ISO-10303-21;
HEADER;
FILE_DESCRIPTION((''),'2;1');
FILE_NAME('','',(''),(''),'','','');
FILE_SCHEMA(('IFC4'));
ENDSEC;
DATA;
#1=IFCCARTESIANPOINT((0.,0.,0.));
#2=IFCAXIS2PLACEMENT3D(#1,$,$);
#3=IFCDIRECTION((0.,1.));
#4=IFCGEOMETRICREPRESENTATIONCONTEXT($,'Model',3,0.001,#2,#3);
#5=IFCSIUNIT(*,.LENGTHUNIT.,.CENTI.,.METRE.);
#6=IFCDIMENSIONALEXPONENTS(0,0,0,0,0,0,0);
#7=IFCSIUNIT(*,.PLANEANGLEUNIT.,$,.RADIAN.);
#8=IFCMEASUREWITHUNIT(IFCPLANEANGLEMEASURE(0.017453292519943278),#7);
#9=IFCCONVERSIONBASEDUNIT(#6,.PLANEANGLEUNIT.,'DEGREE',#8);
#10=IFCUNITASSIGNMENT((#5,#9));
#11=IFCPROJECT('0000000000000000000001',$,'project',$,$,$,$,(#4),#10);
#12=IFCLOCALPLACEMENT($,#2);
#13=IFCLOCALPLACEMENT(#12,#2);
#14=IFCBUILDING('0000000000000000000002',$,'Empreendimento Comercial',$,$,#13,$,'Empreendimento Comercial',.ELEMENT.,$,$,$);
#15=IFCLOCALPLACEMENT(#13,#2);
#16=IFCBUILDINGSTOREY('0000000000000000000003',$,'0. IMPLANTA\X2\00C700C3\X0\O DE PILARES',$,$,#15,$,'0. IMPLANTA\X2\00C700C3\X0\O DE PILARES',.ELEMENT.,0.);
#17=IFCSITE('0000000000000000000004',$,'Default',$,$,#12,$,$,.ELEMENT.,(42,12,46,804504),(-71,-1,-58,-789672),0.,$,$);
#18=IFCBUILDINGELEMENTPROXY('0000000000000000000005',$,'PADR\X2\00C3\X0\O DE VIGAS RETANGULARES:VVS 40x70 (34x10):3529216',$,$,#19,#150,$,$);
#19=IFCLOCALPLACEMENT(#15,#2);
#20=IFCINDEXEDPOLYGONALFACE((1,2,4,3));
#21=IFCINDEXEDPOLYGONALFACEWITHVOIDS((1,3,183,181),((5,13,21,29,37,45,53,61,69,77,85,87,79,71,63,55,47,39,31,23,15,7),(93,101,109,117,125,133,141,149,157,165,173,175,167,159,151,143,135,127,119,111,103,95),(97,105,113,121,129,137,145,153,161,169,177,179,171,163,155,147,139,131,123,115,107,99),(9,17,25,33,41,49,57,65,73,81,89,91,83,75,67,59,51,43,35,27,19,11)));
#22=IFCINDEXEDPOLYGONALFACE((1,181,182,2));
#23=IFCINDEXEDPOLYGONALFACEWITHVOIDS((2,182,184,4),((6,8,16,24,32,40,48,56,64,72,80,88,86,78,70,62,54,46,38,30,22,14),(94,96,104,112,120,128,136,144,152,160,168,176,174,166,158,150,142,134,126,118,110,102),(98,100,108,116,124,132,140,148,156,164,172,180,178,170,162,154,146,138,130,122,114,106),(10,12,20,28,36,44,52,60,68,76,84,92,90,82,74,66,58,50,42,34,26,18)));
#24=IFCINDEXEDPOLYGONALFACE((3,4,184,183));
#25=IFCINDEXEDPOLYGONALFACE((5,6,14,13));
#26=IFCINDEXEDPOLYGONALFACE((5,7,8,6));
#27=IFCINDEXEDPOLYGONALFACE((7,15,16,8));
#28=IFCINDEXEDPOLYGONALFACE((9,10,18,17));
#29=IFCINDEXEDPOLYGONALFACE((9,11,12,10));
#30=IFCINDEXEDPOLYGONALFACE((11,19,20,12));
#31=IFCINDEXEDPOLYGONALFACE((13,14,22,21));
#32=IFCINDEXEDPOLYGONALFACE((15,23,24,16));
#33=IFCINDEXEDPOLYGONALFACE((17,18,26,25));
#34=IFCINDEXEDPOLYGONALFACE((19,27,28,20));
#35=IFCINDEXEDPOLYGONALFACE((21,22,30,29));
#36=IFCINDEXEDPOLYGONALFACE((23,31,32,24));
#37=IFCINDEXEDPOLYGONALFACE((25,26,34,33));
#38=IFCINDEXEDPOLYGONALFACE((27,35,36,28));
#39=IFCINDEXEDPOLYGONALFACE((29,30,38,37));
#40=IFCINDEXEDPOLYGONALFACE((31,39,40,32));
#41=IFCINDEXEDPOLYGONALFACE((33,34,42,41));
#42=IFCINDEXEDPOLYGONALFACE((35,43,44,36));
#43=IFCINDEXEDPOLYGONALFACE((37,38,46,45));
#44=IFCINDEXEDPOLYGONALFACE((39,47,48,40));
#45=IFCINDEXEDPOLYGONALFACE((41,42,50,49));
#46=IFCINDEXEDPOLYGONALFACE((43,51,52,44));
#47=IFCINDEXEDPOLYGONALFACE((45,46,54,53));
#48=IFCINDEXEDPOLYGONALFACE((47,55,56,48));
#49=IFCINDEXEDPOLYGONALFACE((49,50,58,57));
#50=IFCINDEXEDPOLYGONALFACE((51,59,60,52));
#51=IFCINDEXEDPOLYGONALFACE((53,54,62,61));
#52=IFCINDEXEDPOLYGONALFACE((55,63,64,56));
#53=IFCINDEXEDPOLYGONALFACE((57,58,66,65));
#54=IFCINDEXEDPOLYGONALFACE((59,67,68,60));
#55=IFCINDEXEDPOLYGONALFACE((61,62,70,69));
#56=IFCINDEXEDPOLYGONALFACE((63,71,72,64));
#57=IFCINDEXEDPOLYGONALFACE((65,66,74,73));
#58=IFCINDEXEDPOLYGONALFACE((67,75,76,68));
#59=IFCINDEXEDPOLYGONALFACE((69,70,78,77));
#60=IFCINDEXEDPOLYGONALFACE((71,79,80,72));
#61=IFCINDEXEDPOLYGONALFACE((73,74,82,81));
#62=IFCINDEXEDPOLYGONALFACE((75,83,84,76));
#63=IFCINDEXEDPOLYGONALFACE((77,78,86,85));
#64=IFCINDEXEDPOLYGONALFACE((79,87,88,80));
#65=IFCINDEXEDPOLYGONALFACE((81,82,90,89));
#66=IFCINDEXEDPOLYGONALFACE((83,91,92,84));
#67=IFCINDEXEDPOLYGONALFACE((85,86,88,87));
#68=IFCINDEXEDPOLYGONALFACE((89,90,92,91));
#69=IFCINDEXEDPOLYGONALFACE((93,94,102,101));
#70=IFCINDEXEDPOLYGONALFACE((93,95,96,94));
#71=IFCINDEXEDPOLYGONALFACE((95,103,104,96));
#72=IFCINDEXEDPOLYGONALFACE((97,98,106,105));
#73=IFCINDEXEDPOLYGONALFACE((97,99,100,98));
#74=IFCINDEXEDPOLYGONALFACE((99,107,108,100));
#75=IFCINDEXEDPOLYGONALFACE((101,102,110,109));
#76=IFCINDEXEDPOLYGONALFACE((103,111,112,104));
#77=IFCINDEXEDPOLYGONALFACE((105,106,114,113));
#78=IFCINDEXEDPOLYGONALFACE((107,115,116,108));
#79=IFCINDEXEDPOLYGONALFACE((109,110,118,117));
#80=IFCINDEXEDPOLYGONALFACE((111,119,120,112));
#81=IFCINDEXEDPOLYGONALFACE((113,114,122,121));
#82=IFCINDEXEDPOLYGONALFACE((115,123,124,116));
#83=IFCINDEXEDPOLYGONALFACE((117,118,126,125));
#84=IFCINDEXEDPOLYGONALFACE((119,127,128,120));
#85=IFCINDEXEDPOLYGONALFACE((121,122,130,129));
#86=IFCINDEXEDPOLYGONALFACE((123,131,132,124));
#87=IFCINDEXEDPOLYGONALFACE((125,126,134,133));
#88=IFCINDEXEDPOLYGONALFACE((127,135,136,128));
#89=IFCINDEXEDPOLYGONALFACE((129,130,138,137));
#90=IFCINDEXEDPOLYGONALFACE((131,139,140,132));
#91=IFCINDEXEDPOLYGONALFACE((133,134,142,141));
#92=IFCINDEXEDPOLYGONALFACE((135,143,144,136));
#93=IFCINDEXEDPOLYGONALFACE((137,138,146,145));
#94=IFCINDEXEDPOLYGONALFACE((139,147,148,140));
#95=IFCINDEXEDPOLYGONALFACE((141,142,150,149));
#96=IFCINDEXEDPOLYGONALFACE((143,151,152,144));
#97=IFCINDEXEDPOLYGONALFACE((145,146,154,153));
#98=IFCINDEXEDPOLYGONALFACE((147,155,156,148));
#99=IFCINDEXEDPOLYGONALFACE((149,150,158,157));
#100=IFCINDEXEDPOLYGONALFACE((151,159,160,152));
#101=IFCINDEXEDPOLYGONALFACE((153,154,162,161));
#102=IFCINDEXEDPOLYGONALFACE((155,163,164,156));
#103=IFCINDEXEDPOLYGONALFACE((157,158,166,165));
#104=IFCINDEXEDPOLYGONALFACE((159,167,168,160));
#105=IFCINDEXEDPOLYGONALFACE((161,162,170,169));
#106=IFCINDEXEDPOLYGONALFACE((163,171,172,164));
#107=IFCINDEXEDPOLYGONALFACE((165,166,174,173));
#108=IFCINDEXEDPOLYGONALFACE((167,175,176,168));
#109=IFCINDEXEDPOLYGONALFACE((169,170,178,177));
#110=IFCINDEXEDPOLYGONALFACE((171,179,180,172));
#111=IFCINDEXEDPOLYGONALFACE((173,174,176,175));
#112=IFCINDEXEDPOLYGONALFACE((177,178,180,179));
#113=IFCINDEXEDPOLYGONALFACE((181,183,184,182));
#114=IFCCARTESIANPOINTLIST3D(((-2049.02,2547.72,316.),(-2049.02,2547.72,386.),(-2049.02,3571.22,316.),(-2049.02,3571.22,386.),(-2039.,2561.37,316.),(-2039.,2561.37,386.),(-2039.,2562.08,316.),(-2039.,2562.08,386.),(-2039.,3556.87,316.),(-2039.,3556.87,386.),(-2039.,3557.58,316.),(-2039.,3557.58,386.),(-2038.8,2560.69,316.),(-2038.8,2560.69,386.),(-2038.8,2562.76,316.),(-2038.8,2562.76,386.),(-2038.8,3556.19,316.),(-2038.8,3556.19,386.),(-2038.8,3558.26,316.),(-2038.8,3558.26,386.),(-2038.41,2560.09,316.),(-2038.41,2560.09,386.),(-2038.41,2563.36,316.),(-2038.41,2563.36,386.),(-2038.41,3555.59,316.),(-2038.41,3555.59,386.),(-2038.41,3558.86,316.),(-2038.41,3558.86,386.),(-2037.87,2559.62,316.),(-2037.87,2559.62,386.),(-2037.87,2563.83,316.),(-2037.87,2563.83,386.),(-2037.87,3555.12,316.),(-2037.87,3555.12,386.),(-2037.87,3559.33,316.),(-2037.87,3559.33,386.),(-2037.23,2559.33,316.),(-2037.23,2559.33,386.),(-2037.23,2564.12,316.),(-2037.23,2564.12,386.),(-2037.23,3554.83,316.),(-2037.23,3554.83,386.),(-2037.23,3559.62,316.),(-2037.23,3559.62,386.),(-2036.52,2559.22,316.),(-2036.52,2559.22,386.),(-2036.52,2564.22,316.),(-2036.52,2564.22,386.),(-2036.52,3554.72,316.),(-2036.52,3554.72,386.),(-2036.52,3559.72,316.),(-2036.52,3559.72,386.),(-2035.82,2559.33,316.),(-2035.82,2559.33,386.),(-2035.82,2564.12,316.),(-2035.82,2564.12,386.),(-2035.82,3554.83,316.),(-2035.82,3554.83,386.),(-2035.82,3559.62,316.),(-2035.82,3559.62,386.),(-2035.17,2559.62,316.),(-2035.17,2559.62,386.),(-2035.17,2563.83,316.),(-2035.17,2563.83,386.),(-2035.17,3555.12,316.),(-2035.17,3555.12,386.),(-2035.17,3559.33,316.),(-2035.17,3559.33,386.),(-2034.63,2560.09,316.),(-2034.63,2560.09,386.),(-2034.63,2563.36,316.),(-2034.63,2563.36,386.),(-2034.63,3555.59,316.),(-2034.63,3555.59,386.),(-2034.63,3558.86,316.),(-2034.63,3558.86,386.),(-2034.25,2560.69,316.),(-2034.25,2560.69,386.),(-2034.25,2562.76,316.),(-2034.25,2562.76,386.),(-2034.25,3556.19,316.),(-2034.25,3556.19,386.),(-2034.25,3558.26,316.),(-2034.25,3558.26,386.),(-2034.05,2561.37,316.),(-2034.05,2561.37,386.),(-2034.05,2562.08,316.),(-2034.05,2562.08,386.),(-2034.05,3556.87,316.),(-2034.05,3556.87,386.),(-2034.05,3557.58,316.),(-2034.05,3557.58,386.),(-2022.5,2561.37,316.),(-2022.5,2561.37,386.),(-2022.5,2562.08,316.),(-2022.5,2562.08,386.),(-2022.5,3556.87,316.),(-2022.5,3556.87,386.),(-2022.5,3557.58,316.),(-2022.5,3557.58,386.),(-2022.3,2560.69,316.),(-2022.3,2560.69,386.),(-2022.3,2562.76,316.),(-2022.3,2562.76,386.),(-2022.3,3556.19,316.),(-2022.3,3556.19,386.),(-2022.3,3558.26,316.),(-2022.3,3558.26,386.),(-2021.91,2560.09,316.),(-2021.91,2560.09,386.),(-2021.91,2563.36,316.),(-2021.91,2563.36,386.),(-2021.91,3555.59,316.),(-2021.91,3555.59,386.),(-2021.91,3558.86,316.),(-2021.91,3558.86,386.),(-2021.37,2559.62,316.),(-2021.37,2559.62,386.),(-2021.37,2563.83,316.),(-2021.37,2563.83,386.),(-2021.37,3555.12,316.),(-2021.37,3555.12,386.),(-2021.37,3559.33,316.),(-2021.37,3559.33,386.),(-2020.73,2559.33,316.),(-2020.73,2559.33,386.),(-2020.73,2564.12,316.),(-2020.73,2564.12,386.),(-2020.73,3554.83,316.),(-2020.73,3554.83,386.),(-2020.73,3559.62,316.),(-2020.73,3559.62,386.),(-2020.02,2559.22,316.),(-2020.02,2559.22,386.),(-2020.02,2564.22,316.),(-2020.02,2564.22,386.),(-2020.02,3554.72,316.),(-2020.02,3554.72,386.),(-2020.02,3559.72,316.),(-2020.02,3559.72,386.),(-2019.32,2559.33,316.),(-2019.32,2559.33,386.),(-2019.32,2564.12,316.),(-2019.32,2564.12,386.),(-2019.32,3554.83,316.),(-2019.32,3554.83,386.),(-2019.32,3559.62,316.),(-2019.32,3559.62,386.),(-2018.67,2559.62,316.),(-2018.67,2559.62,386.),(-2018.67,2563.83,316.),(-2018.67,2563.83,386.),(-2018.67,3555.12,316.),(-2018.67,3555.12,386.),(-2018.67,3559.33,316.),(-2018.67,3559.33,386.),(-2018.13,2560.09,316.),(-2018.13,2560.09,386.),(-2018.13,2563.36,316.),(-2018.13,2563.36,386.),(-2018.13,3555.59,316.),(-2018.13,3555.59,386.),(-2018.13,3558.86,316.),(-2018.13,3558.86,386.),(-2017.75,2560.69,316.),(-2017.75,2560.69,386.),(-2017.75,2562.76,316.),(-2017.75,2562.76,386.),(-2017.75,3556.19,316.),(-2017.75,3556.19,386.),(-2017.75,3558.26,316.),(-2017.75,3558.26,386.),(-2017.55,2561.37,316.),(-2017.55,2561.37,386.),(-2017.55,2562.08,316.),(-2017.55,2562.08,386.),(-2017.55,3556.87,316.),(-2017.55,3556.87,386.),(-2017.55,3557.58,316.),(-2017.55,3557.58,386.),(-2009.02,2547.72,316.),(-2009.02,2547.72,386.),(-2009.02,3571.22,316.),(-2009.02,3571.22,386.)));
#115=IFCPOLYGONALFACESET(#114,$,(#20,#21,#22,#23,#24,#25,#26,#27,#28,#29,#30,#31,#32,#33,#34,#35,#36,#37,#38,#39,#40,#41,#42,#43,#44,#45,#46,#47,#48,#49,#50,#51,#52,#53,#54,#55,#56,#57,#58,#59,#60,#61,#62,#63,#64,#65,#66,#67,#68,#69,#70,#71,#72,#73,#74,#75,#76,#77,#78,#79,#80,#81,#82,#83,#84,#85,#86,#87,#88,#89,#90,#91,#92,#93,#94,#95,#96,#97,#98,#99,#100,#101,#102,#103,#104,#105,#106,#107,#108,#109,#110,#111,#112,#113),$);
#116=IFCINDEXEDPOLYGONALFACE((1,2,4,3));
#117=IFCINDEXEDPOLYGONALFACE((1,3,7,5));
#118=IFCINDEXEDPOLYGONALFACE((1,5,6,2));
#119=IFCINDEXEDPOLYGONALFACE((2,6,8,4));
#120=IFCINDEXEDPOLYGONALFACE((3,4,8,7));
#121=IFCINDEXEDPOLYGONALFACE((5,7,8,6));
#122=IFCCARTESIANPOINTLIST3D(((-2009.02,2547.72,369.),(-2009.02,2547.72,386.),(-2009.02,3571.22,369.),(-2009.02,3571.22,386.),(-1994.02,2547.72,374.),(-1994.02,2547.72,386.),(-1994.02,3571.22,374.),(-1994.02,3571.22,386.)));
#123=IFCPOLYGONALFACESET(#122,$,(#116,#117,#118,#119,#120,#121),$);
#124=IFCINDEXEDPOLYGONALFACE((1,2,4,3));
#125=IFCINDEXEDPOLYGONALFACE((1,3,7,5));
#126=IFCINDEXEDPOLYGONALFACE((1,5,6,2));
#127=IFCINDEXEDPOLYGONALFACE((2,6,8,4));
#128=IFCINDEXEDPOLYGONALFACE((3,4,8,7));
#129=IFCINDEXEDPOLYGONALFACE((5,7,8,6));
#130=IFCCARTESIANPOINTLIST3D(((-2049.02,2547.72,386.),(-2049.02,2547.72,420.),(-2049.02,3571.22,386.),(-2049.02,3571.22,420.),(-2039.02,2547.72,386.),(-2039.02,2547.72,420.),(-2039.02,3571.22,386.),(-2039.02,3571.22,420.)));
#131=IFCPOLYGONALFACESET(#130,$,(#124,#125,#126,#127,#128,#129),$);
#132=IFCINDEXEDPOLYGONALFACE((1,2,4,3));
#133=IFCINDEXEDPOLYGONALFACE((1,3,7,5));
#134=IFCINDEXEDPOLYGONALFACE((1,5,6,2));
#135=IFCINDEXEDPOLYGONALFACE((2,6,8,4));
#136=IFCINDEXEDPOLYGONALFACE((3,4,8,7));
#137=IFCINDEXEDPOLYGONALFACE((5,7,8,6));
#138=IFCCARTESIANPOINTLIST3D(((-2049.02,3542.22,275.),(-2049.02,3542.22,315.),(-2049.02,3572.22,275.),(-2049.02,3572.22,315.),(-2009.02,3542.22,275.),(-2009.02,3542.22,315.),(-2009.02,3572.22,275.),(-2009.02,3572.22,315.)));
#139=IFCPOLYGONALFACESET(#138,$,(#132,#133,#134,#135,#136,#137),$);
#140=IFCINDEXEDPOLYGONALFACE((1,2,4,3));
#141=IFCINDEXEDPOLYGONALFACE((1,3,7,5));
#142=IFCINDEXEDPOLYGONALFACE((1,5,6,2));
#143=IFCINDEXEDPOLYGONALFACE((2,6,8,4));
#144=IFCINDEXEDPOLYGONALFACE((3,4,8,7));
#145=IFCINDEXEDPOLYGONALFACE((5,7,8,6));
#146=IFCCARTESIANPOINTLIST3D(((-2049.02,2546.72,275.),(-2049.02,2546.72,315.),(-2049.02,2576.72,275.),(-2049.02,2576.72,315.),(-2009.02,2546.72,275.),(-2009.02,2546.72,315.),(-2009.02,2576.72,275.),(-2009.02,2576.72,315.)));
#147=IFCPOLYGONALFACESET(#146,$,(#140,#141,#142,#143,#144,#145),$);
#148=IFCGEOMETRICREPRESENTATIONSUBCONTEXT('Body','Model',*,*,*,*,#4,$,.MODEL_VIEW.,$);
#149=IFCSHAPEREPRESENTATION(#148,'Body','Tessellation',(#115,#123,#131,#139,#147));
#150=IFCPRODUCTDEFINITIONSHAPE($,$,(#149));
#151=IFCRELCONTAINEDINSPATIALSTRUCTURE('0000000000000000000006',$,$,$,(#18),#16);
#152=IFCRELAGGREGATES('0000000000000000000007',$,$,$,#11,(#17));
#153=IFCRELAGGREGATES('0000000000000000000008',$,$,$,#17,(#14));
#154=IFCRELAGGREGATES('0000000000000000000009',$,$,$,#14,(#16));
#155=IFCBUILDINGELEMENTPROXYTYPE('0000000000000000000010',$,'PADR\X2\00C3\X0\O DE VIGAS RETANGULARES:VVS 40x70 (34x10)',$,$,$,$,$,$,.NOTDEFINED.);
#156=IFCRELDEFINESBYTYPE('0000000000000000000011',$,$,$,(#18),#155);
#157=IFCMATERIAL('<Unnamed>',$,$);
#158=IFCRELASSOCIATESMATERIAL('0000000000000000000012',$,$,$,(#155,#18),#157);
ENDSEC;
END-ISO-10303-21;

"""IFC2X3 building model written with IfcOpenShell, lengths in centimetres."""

from ifc_helpers import new_model, entity, si_unit, converted_unit, direction, frame, frame_2d, origin, origin_2d_with_axis, place, context, subcontext, project, spatial, polyline, circle_curve, parameter, trimmed, segment, composite_curve, rectangle, outline, extrude, source, transform, mapped, material, type_object, type_shapes, element, save


model = new_model("IFC2X3")

# Units and contexts
model_context = context("Model", 3, precision=0.001, world=origin(), true_north=direction((0.0, 1.0)))
body_context = subcontext(model_context, "Body", "Model", "MODEL_VIEW")
ifc_project = project(units=[si_unit("LENGTHUNIT", "METRE", prefix="CENTI"), converted_unit("PLANEANGLEUNIT", "DEGREE", entity("IfcPlaneAngleMeasure", 0.017453292519943278), si_unit("PLANEANGLEUNIT", "RADIAN"), dimensions=[0, 0, 0, 0, 0, 0, 0])], contexts=[model_context])

# Site, building, storey
site_placement = place(None, origin())
site = spatial("IfcSite", under=ifc_project, at=site_placement, Name="Default", CompositionType="ELEMENT", RefLatitude=(42, 12, 46, 804504), RefLongitude=(-71, -1, -58, -789672), RefElevation=0.0)
building_placement = place(site_placement, origin())
building = spatial("IfcBuilding", under=site, at=building_placement, Name="Empreendimento Comercial", LongName="Empreendimento Comercial", CompositionType="ELEMENT")
storey_placement = place(building_placement, origin())
storey = spatial("IfcBuildingStorey", under=building, at=storey_placement, Name="0. IMPLANTAÇÃO DE PILARES", LongName="0. IMPLANTAÇÃO DE PILARES", CompositionType="ELEMENT", Elevation=0.0)

# Building element proxy
ifc_material_1 = material(Name="<Unnamed>")
building_element_proxy_type_1 = type_object("IfcBuildingElementProxyType", Name="PADRÃO DE VIGAS RETANGULARES:VVS 40x70 (34x10)", PredefinedType="NOTDEFINED", material=ifc_material_1)
shared_shape_1 = source(origin(), body_context, "Body", "SweptSolid", [
    extrude(outline(polyline([(-20.0, -511.75), (20.0, -511.75), (20.0, 511.75), (-20.0, 511.75), (-20.0, -511.75)]), holes=[composite_curve([segment(trimmed(circle_curve(frame_2d((9.0, 497.75), x_axis=(0.0, -1.0)), 2.5), [parameter(0.0)], [parameter(180.0)], True, "PARAMETER"), False, "CONTINUOUS"), segment(trimmed(circle_curve(frame_2d((9.0, 497.75), x_axis=(0.0, -1.0)), 2.5), [parameter(180.0)], [parameter(0.0)], True, "PARAMETER"), False, "CONTINUOUS")], self_intersect=False), composite_curve([segment(trimmed(circle_curve(frame_2d((-7.5, 497.75), x_axis=(0.0, -1.0)), 2.5), [parameter(0.0)], [parameter(180.0)], True, "PARAMETER"), False, "CONTINUOUS"), segment(trimmed(circle_curve(frame_2d((-7.5, 497.75), x_axis=(0.0, -1.0)), 2.5), [parameter(180.0)], [parameter(0.0)], True, "PARAMETER"), False, "CONTINUOUS")], self_intersect=False), composite_curve([segment(trimmed(circle_curve(frame_2d((-7.5, -497.75), x_axis=(0.0, -1.0)), 2.5), [parameter(0.0)], [parameter(180.0)], True, "PARAMETER"), False, "CONTINUOUS"), segment(trimmed(circle_curve(frame_2d((-7.5, -497.75), x_axis=(0.0, -1.0)), 2.5), [parameter(180.0)], [parameter(0.0)], True, "PARAMETER"), False, "CONTINUOUS")], self_intersect=False), composite_curve([segment(trimmed(circle_curve(frame_2d((9.0, -497.75), x_axis=(0.0, -1.0)), 2.5), [parameter(0.0)], [parameter(180.0)], True, "PARAMETER"), False, "CONTINUOUS"), segment(trimmed(circle_curve(frame_2d((9.0, -497.75), x_axis=(0.0, -1.0)), 2.5), [parameter(180.0)], [parameter(0.0)], True, "PARAMETER"), False, "CONTINUOUS")], self_intersect=False)]), frame((-2029.02, 3059.47, 316.0)), (0.0, 0.0, 1.0), 70.0),
    extrude(outline(polyline([(-7.25, -7.5), (4.75, -7.5), (9.75, 7.5), (-7.25, 7.5), (-7.25, -7.5)])), frame((-2001.52, 2547.72, 378.75), z_axis=(0.0, 1.0, 0.0), x_axis=(0.0, 0.0, -1.0)), (0.0, 0.0, 1.0), 1023.5),
    extrude(rectangle(XDim=10.0, YDim=1023.5, at=frame_2d((0.0, 0.0), x_axis=(1.0, 0.0))), frame((-2044.02, 3059.47, 386.0)), (0.0, 0.0, 1.0), 34.0),
    extrude(rectangle(XDim=30.0, YDim=40.0, at=frame_2d((0.0, 0.0), x_axis=(1.0, 0.0))), frame((-2029.02, 3557.22, 275.0), z_axis=(0.0, 0.0, 1.0), x_axis=(0.0, 1.0, 0.0)), (0.0, 0.0, 1.0), 40.0),
    extrude(rectangle(XDim=30.0, YDim=40.0, at=origin_2d_with_axis()), frame((-2029.02, 2561.72, 275.0), z_axis=(0.0, 0.0, 1.0), x_axis=(0.0, 1.0, 0.0)), (0.0, 0.0, 1.0), 40.0),
])
type_shapes(building_element_proxy_type_1, [shared_shape_1])
proxy_1_placement = place(storey_placement, origin())
element("IfcBuildingElementProxy", 1, at=proxy_1_placement, inside=storey, type_object=building_element_proxy_type_1, material=ifc_material_1, Name="PADRÃO DE VIGAS RETANGULARES:VVS 40x70 (34x10):3529216", context=body_context, shape_type="MappedRepresentation", body=[
    mapped(shared_shape_1, transform((0.0, 0.0, 0.0), scale=1.0)),
])

save(model, "model.ifc")
